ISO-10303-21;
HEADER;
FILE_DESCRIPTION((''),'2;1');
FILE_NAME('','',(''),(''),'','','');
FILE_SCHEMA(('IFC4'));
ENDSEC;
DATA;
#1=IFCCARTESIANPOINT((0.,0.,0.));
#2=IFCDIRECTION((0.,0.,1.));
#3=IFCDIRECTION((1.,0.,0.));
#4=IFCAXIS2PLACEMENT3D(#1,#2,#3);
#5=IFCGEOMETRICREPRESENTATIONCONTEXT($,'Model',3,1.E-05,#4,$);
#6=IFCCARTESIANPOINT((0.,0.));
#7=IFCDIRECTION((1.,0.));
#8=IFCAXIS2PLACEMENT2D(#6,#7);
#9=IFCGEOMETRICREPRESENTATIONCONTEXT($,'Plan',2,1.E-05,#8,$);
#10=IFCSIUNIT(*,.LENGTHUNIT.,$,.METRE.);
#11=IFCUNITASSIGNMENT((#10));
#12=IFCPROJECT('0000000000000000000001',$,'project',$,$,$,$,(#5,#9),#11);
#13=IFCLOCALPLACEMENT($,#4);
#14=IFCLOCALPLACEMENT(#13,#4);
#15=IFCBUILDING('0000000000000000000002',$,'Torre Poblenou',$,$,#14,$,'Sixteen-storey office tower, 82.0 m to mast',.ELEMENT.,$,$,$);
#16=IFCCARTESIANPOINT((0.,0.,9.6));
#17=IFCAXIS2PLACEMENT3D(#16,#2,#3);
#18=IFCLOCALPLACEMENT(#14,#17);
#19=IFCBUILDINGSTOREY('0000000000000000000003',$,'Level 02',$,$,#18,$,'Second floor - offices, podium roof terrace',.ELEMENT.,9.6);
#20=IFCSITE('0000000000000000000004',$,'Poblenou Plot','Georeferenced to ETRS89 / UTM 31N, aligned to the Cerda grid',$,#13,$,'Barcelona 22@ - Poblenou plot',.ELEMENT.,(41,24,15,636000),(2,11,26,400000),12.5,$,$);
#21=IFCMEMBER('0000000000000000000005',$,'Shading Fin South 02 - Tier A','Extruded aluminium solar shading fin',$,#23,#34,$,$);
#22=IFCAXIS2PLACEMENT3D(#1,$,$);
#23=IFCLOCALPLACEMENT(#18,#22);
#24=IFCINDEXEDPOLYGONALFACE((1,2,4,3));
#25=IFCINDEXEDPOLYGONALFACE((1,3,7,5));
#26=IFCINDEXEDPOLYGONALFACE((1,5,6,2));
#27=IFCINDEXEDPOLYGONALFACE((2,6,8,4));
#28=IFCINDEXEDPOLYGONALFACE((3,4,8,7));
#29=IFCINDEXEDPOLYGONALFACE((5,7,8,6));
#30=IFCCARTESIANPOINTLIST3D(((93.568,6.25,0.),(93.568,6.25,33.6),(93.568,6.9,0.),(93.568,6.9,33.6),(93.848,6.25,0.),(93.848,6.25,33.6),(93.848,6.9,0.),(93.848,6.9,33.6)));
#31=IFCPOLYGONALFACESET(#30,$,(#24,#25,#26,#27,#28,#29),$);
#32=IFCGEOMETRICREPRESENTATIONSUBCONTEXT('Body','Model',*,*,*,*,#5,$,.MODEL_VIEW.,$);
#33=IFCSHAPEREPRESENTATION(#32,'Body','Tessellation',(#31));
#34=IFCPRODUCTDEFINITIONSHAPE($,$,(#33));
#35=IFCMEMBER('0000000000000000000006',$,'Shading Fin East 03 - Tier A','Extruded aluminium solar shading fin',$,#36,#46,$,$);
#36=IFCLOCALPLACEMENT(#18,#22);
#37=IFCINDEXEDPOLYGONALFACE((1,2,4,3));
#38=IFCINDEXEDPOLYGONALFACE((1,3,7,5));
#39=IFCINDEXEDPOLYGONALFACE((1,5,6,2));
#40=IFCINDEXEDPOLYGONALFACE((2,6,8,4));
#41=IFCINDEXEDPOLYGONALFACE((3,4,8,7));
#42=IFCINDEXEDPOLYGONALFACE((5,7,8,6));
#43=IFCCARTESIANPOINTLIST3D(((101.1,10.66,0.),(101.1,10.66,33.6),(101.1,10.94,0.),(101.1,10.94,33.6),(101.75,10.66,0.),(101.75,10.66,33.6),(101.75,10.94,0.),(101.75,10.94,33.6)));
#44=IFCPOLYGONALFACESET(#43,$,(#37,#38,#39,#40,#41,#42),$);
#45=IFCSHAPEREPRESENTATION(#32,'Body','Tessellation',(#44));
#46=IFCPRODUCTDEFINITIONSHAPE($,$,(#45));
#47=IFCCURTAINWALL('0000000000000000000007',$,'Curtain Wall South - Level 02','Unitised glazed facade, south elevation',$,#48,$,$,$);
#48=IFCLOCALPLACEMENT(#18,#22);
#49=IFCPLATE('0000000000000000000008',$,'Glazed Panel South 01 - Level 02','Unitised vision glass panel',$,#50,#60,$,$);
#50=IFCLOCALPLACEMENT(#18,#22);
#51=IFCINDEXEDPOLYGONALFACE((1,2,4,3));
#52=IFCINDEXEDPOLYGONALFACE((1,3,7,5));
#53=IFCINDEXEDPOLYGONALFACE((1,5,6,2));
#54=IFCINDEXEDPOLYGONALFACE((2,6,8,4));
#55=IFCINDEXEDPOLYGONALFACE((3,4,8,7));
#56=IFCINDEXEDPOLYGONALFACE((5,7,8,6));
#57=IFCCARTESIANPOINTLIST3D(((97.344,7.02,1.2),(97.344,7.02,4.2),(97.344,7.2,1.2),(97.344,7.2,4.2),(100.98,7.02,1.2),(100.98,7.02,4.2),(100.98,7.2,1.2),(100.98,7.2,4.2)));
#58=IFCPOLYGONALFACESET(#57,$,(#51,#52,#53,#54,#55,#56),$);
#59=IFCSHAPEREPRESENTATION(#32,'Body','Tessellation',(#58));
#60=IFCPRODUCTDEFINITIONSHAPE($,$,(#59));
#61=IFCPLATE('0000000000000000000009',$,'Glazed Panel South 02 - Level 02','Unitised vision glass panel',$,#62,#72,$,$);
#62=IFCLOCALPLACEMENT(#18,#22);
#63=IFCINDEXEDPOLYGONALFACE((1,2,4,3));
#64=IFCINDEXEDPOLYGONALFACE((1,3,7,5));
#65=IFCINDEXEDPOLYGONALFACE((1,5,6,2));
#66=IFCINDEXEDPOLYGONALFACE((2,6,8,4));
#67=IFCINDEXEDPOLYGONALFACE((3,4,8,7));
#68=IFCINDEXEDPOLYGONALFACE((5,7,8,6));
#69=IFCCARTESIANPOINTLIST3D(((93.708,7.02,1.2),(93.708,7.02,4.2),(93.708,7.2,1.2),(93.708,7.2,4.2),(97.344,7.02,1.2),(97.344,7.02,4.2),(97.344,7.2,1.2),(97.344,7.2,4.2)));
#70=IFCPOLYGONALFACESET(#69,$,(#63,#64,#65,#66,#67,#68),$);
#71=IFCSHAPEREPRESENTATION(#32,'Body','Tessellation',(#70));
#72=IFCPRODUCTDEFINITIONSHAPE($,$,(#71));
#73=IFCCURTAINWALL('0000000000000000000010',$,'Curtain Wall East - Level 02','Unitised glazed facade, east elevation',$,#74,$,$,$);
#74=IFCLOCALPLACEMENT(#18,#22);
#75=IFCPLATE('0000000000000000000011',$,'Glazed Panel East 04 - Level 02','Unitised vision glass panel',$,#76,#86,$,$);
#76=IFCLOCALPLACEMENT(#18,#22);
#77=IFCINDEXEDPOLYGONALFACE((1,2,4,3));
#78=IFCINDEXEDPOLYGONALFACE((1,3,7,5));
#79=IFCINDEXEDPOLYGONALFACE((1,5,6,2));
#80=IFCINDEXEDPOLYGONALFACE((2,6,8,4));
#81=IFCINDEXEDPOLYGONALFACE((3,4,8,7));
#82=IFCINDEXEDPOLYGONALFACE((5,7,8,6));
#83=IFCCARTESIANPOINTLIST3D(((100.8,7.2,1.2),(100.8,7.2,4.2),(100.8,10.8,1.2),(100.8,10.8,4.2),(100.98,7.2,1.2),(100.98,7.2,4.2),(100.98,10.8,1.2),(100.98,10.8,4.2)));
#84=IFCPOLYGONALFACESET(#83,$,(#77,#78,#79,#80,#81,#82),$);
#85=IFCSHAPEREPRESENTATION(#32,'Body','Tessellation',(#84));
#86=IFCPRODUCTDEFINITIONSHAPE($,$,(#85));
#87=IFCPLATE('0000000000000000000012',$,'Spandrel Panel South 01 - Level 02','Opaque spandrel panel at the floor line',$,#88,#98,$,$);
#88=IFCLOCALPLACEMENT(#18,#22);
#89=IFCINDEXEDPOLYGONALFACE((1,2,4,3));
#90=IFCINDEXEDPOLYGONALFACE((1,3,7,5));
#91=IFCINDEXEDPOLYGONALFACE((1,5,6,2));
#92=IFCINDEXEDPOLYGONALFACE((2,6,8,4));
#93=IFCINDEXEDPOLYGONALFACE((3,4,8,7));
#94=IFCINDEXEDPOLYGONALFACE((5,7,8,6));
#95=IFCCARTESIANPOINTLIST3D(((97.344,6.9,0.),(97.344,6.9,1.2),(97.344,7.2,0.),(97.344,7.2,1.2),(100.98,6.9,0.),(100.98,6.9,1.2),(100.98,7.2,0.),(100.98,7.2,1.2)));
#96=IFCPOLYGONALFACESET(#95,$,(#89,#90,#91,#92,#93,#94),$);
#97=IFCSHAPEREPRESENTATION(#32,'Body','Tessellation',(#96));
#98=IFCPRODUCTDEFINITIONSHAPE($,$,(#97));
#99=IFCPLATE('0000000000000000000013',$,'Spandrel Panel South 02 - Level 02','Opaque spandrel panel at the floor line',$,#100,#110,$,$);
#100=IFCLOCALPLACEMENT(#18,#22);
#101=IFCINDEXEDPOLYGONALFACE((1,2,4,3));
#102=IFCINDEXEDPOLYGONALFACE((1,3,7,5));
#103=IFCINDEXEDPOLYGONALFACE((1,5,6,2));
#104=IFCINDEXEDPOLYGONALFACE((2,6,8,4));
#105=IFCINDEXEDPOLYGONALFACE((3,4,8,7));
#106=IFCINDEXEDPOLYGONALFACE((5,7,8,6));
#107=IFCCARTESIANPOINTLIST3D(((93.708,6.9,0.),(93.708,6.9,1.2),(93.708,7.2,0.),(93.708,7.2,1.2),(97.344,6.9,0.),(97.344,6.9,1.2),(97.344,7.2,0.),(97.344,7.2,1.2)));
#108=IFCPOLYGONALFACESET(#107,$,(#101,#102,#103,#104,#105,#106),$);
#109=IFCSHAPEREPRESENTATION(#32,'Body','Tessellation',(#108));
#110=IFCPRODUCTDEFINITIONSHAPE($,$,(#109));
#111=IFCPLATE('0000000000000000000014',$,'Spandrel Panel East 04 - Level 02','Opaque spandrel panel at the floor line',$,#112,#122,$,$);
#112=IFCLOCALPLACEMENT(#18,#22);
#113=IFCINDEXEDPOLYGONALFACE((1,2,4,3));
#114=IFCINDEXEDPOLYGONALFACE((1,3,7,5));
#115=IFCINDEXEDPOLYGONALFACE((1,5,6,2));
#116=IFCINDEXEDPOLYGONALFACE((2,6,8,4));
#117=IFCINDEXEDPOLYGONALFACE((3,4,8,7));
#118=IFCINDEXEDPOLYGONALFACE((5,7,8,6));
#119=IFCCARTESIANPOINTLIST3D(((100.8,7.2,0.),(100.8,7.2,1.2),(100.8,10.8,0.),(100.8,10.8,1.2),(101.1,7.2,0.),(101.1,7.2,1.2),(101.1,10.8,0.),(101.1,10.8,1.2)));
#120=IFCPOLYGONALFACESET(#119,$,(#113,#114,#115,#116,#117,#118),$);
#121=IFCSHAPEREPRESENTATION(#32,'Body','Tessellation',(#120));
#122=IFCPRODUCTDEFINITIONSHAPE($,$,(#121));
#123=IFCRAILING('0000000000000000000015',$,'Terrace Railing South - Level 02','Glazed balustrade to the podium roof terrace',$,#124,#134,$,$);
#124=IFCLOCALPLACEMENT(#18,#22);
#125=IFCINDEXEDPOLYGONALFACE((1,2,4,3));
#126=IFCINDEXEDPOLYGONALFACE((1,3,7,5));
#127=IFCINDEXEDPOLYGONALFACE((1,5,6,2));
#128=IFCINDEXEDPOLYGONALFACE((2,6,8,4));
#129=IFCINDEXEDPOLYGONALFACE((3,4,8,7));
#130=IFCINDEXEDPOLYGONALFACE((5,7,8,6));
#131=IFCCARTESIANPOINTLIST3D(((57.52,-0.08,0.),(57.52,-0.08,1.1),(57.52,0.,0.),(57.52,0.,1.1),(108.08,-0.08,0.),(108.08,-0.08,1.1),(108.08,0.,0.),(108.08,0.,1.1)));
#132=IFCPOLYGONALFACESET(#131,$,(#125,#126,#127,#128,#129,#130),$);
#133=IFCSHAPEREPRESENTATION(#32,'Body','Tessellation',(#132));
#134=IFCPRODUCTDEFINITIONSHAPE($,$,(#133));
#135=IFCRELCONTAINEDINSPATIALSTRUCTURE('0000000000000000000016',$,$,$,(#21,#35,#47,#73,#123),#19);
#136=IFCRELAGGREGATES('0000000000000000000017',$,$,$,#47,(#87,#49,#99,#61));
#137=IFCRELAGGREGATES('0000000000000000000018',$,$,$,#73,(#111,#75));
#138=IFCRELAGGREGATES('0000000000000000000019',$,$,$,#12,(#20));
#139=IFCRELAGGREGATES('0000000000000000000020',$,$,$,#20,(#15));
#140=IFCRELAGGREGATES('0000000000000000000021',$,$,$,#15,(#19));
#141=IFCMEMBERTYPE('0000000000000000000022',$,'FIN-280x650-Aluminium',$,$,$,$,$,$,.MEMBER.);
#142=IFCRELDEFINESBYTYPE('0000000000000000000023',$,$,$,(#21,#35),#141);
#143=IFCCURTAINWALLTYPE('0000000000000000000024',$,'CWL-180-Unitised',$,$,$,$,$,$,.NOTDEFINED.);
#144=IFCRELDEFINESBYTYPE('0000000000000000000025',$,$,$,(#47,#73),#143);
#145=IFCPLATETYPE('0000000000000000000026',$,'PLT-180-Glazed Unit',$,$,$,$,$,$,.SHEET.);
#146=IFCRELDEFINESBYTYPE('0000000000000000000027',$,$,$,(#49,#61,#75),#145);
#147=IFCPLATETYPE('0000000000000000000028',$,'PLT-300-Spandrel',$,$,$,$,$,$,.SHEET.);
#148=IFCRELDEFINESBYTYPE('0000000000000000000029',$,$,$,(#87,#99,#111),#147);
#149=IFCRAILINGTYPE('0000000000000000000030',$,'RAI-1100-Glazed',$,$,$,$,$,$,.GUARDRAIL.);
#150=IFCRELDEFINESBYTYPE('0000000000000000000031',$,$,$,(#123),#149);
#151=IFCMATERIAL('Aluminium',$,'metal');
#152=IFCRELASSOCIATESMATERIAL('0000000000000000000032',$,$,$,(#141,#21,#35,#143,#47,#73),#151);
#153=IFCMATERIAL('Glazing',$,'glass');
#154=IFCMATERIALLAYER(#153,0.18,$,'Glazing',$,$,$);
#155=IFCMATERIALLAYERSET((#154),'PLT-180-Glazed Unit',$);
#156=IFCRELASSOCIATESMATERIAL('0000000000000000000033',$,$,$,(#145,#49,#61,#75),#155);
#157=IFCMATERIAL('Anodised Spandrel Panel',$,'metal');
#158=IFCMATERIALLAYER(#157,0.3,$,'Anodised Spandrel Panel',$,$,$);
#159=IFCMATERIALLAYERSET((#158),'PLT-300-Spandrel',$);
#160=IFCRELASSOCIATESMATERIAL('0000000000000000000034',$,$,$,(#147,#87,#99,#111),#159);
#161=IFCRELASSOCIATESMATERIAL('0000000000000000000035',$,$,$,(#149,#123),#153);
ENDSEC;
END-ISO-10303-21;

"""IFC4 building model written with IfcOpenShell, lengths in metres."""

from ifc_helpers import new_model, si_unit, frame, origin_with_axes, origin_2d_with_axis, place, context, subcontext, project, spatial, line, indexed_curve, rectangle, outline, extrude, material, layer, layer_set, layer_usage, material_profile, profile_set, profile_usage, type_object, element, aggregate, save


model = new_model("IFC4")

# Units and contexts
model_context = context("Model", 3, precision=1e-05, world=origin_with_axes())
plan_context = context("Plan", 2, precision=1e-05, world=origin_2d_with_axis())
body_context = subcontext(model_context, "Body", "Model", "MODEL_VIEW")
ifc_project = project(units=[si_unit("LENGTHUNIT", "METRE")], contexts=[model_context, plan_context])

# Site, building, storey
site_placement = place(None, origin_with_axes())
site = spatial("IfcSite", under=ifc_project, at=site_placement, Name="Poblenou Plot", Description="Georeferenced to ETRS89 / UTM 31N, aligned to the Cerda grid", LongName="Barcelona 22@ - Poblenou plot", CompositionType="ELEMENT", RefLatitude=(41, 24, 15, 636000), RefLongitude=(2, 11, 26, 400000), RefElevation=12.5)
building_placement = place(site_placement, origin_with_axes())
building = spatial("IfcBuilding", under=site, at=building_placement, Name="Torre Poblenou", LongName="Sixteen-storey office tower, 82.0 m to mast", CompositionType="ELEMENT")
storey_placement = place(building_placement, frame((0.0, 0.0, 9.6), z_axis=(0.0, 0.0, 1.0), x_axis=(1.0, 0.0, 0.0)))
storey = spatial("IfcBuildingStorey", under=building, at=storey_placement, Name="Level 02", LongName="Second floor - offices, podium roof terrace", CompositionType="ELEMENT", Elevation=9.6)

# Members
ifc_material_1 = material(Name="Aluminium", Category="metal")
ifc_material_profile_1 = material_profile(ifc_material_1, rectangle(XDim=0.28, YDim=0.65))
ifc_profile_set_1 = profile_set([ifc_material_profile_1], Name="FIN-280x650-Aluminium")
member_type = type_object("IfcMemberType", Name="FIN-280x650-Aluminium", PredefinedType="MEMBER", material=ifc_profile_set_1)
ifc_profile_usage_1 = profile_usage(ifc_profile_set_1)
member_1_placement = place(storey_placement, frame((93.848, 6.9, 0.0), z_axis=(0.0, 0.0, 1.0), x_axis=(-1.0, 0.0, 0.0)))
element("IfcMember", 1, at=member_1_placement, inside=storey, type_object=member_type, material=ifc_profile_usage_1, Name="Shading Fin South 02 - Tier A", Description="Extruded aluminium solar shading fin", context=body_context, shape_type="SweptSolid", body=[
    extrude(outline(indexed_curve([(0.0, 0.0), (0.28, 0.0), (0.28, 0.65), (0.0, 0.65)], segments=[line(1, 2, 3, 4, 1)])), origin_with_axes(), (0.0, 0.0, 1.0), 33.6),
])
ifc_profile_usage_2 = profile_usage(ifc_profile_set_1)
member_2_placement = place(storey_placement, frame((101.1, 10.94, 0.0), z_axis=(0.0, 0.0, 1.0), x_axis=(0.0, -1.0, 0.0)))
element("IfcMember", 2, at=member_2_placement, inside=storey, type_object=member_type, material=ifc_profile_usage_2, Name="Shading Fin East 03 - Tier A", Description="Extruded aluminium solar shading fin", context=body_context, shape_type="SweptSolid", body=[
    extrude(outline(indexed_curve([(0.0, 0.0), (0.28, 0.0), (0.28, 0.65), (0.0, 0.65)], segments=[line(1, 2, 3, 4, 1)])), origin_with_axes(), (0.0, 0.0, 1.0), 33.6),
])

# Curtain wall, plates
curtain_wall_type = type_object("IfcCurtainWallType", Name="CWL-180-Unitised", PredefinedType="NOTDEFINED", material=ifc_material_1)
curtain_wall_1_placement = place(storey_placement, frame((100.98, 7.2, 0.0), z_axis=(0.0, 0.0, 1.0), x_axis=(-1.0, 0.0, 0.0)))
curtain_wall_1 = element("IfcCurtainWall", 3, at=curtain_wall_1_placement, inside=storey, type_object=curtain_wall_type, material=ifc_material_1, Name="Curtain Wall South - Level 02", Description="Unitised glazed facade, south elevation")
ifc_material_2 = material(Name="Glazing", Category="glass")
ifc_layer_1 = layer(ifc_material_2, 0.18, Name="Glazing")
ifc_layer_set_1 = layer_set([ifc_layer_1], Name="PLT-180-Glazed Unit")
ifc_layer_usage_1 = layer_usage(ifc_layer_set_1, "AXIS2", "POSITIVE", 0.0)
plate_type_1 = type_object("IfcPlateType", Name="PLT-180-Glazed Unit", PredefinedType="SHEET", material=ifc_layer_set_1)
plate_1_placement = place(curtain_wall_1_placement, frame((0.0, 0.0, 1.2), z_axis=(0.0, 0.0, 1.0), x_axis=(1.0, 0.0, 0.0)))
plate_1 = element("IfcPlate", 4, at=plate_1_placement, type_object=plate_type_1, material=ifc_layer_usage_1, Name="Glazed Panel South 01 - Level 02", Description="Unitised vision glass panel", context=body_context, shape_type="SweptSolid", body=[
    extrude(outline(indexed_curve([(0.0, 0.0), (3.636, 0.0), (3.636, 0.18), (0.0, 0.18)], segments=[line(1, 2, 3, 4, 1)])), origin_with_axes(), (0.0, 0.0, 1.0), 3.0),
])
ifc_layer_usage_2 = layer_usage(ifc_layer_set_1, "AXIS2", "POSITIVE", 0.0)
plate_2_placement = place(curtain_wall_1_placement, frame((3.636, 0.0, 1.2), z_axis=(0.0, 0.0, 1.0), x_axis=(1.0, 0.0, 0.0)))
plate_2 = element("IfcPlate", 5, at=plate_2_placement, type_object=plate_type_1, material=ifc_layer_usage_2, Name="Glazed Panel South 02 - Level 02", Description="Unitised vision glass panel", context=body_context, shape_type="SweptSolid", body=[
    extrude(outline(indexed_curve([(0.0, 0.0), (3.636, 0.0), (3.636, 0.18), (0.0, 0.18)], segments=[line(1, 2, 3, 4, 1)])), origin_with_axes(), (0.0, 0.0, 1.0), 3.0),
])

# Curtain wall, plate
curtain_wall_2_placement = place(storey_placement, frame((100.8, 21.6, 0.0), z_axis=(0.0, 0.0, 1.0), x_axis=(0.0, -1.0, 0.0)))
curtain_wall_2 = element("IfcCurtainWall", 6, at=curtain_wall_2_placement, inside=storey, type_object=curtain_wall_type, material=ifc_material_1, Name="Curtain Wall East - Level 02", Description="Unitised glazed facade, east elevation")
ifc_layer_usage_3 = layer_usage(ifc_layer_set_1, "AXIS2", "POSITIVE", 0.0)
plate_3_placement = place(curtain_wall_2_placement, frame((10.8, 0.0, 1.2), z_axis=(0.0, 0.0, 1.0), x_axis=(1.0, 0.0, 0.0)))
plate_3 = element("IfcPlate", 7, at=plate_3_placement, type_object=plate_type_1, material=ifc_layer_usage_3, Name="Glazed Panel East 04 - Level 02", Description="Unitised vision glass panel", context=body_context, shape_type="SweptSolid", body=[
    extrude(outline(indexed_curve([(0.0, 0.0), (3.6, 0.0), (3.6, 0.18), (0.0, 0.18)], segments=[line(1, 2, 3, 4, 1)])), origin_with_axes(), (0.0, 0.0, 1.0), 3.0),
])

# Plates
ifc_material_3 = material(Name="Anodised Spandrel Panel", Category="metal")
ifc_layer_2 = layer(ifc_material_3, 0.3, Name="Anodised Spandrel Panel")
ifc_layer_set_2 = layer_set([ifc_layer_2], Name="PLT-300-Spandrel")
ifc_layer_usage_4 = layer_usage(ifc_layer_set_2, "AXIS2", "POSITIVE", 0.0)
plate_type_2 = type_object("IfcPlateType", Name="PLT-300-Spandrel", PredefinedType="SHEET", material=ifc_layer_set_2)
plate_4_placement = place(curtain_wall_1_placement, origin_with_axes())
plate_4 = element("IfcPlate", 8, at=plate_4_placement, type_object=plate_type_2, material=ifc_layer_usage_4, Name="Spandrel Panel South 01 - Level 02", Description="Opaque spandrel panel at the floor line", context=body_context, shape_type="SweptSolid", body=[
    extrude(outline(indexed_curve([(0.0, 0.0), (3.636, 0.0), (3.636, 0.3), (0.0, 0.3)], segments=[line(1, 2, 3, 4, 1)])), origin_with_axes(), (0.0, 0.0, 1.0), 1.2),
])
ifc_layer_usage_5 = layer_usage(ifc_layer_set_2, "AXIS2", "POSITIVE", 0.0)
plate_5_placement = place(curtain_wall_1_placement, frame((3.636, 0.0, 0.0), z_axis=(0.0, 0.0, 1.0), x_axis=(1.0, 0.0, 0.0)))
plate_5 = element("IfcPlate", 9, at=plate_5_placement, type_object=plate_type_2, material=ifc_layer_usage_5, Name="Spandrel Panel South 02 - Level 02", Description="Opaque spandrel panel at the floor line", context=body_context, shape_type="SweptSolid", body=[
    extrude(outline(indexed_curve([(0.0, 0.0), (3.636, 0.0), (3.636, 0.3), (0.0, 0.3)], segments=[line(1, 2, 3, 4, 1)])), origin_with_axes(), (0.0, 0.0, 1.0), 1.2),
])
aggregate(curtain_wall_1, [plate_4, plate_1, plate_5, plate_2])
ifc_layer_usage_6 = layer_usage(ifc_layer_set_2, "AXIS2", "POSITIVE", 0.0)
plate_6_placement = place(curtain_wall_2_placement, frame((10.8, 0.0, 0.0), z_axis=(0.0, 0.0, 1.0), x_axis=(1.0, 0.0, 0.0)))
plate_6 = element("IfcPlate", 10, at=plate_6_placement, type_object=plate_type_2, material=ifc_layer_usage_6, Name="Spandrel Panel East 04 - Level 02", Description="Opaque spandrel panel at the floor line", context=body_context, shape_type="SweptSolid", body=[
    extrude(outline(indexed_curve([(0.0, 0.0), (3.6, 0.0), (3.6, 0.3), (0.0, 0.3)], segments=[line(1, 2, 3, 4, 1)])), origin_with_axes(), (0.0, 0.0, 1.0), 1.2),
])
aggregate(curtain_wall_2, [plate_6, plate_3])

# Railing
railing_type = type_object("IfcRailingType", Name="RAI-1100-Glazed", PredefinedType="GUARDRAIL", material=ifc_material_2)
railing_placement = place(storey_placement, frame((108.08, 0.0, 0.0), z_axis=(0.0, 0.0, 1.0), x_axis=(-1.0, 0.0, 0.0)))
element("IfcRailing", 11, at=railing_placement, inside=storey, type_object=railing_type, material=ifc_material_2, Name="Terrace Railing South - Level 02", Description="Glazed balustrade to the podium roof terrace", context=body_context, shape_type="SweptSolid", body=[
    extrude(outline(indexed_curve([(0.0, 0.0), (50.56, 0.0), (50.56, 0.08), (0.0, 0.08)], segments=[line(1, 2, 3, 4, 1)])), origin_with_axes(), (0.0, 0.0, 1.0), 1.1),
])

save(model, "model.ifc")
